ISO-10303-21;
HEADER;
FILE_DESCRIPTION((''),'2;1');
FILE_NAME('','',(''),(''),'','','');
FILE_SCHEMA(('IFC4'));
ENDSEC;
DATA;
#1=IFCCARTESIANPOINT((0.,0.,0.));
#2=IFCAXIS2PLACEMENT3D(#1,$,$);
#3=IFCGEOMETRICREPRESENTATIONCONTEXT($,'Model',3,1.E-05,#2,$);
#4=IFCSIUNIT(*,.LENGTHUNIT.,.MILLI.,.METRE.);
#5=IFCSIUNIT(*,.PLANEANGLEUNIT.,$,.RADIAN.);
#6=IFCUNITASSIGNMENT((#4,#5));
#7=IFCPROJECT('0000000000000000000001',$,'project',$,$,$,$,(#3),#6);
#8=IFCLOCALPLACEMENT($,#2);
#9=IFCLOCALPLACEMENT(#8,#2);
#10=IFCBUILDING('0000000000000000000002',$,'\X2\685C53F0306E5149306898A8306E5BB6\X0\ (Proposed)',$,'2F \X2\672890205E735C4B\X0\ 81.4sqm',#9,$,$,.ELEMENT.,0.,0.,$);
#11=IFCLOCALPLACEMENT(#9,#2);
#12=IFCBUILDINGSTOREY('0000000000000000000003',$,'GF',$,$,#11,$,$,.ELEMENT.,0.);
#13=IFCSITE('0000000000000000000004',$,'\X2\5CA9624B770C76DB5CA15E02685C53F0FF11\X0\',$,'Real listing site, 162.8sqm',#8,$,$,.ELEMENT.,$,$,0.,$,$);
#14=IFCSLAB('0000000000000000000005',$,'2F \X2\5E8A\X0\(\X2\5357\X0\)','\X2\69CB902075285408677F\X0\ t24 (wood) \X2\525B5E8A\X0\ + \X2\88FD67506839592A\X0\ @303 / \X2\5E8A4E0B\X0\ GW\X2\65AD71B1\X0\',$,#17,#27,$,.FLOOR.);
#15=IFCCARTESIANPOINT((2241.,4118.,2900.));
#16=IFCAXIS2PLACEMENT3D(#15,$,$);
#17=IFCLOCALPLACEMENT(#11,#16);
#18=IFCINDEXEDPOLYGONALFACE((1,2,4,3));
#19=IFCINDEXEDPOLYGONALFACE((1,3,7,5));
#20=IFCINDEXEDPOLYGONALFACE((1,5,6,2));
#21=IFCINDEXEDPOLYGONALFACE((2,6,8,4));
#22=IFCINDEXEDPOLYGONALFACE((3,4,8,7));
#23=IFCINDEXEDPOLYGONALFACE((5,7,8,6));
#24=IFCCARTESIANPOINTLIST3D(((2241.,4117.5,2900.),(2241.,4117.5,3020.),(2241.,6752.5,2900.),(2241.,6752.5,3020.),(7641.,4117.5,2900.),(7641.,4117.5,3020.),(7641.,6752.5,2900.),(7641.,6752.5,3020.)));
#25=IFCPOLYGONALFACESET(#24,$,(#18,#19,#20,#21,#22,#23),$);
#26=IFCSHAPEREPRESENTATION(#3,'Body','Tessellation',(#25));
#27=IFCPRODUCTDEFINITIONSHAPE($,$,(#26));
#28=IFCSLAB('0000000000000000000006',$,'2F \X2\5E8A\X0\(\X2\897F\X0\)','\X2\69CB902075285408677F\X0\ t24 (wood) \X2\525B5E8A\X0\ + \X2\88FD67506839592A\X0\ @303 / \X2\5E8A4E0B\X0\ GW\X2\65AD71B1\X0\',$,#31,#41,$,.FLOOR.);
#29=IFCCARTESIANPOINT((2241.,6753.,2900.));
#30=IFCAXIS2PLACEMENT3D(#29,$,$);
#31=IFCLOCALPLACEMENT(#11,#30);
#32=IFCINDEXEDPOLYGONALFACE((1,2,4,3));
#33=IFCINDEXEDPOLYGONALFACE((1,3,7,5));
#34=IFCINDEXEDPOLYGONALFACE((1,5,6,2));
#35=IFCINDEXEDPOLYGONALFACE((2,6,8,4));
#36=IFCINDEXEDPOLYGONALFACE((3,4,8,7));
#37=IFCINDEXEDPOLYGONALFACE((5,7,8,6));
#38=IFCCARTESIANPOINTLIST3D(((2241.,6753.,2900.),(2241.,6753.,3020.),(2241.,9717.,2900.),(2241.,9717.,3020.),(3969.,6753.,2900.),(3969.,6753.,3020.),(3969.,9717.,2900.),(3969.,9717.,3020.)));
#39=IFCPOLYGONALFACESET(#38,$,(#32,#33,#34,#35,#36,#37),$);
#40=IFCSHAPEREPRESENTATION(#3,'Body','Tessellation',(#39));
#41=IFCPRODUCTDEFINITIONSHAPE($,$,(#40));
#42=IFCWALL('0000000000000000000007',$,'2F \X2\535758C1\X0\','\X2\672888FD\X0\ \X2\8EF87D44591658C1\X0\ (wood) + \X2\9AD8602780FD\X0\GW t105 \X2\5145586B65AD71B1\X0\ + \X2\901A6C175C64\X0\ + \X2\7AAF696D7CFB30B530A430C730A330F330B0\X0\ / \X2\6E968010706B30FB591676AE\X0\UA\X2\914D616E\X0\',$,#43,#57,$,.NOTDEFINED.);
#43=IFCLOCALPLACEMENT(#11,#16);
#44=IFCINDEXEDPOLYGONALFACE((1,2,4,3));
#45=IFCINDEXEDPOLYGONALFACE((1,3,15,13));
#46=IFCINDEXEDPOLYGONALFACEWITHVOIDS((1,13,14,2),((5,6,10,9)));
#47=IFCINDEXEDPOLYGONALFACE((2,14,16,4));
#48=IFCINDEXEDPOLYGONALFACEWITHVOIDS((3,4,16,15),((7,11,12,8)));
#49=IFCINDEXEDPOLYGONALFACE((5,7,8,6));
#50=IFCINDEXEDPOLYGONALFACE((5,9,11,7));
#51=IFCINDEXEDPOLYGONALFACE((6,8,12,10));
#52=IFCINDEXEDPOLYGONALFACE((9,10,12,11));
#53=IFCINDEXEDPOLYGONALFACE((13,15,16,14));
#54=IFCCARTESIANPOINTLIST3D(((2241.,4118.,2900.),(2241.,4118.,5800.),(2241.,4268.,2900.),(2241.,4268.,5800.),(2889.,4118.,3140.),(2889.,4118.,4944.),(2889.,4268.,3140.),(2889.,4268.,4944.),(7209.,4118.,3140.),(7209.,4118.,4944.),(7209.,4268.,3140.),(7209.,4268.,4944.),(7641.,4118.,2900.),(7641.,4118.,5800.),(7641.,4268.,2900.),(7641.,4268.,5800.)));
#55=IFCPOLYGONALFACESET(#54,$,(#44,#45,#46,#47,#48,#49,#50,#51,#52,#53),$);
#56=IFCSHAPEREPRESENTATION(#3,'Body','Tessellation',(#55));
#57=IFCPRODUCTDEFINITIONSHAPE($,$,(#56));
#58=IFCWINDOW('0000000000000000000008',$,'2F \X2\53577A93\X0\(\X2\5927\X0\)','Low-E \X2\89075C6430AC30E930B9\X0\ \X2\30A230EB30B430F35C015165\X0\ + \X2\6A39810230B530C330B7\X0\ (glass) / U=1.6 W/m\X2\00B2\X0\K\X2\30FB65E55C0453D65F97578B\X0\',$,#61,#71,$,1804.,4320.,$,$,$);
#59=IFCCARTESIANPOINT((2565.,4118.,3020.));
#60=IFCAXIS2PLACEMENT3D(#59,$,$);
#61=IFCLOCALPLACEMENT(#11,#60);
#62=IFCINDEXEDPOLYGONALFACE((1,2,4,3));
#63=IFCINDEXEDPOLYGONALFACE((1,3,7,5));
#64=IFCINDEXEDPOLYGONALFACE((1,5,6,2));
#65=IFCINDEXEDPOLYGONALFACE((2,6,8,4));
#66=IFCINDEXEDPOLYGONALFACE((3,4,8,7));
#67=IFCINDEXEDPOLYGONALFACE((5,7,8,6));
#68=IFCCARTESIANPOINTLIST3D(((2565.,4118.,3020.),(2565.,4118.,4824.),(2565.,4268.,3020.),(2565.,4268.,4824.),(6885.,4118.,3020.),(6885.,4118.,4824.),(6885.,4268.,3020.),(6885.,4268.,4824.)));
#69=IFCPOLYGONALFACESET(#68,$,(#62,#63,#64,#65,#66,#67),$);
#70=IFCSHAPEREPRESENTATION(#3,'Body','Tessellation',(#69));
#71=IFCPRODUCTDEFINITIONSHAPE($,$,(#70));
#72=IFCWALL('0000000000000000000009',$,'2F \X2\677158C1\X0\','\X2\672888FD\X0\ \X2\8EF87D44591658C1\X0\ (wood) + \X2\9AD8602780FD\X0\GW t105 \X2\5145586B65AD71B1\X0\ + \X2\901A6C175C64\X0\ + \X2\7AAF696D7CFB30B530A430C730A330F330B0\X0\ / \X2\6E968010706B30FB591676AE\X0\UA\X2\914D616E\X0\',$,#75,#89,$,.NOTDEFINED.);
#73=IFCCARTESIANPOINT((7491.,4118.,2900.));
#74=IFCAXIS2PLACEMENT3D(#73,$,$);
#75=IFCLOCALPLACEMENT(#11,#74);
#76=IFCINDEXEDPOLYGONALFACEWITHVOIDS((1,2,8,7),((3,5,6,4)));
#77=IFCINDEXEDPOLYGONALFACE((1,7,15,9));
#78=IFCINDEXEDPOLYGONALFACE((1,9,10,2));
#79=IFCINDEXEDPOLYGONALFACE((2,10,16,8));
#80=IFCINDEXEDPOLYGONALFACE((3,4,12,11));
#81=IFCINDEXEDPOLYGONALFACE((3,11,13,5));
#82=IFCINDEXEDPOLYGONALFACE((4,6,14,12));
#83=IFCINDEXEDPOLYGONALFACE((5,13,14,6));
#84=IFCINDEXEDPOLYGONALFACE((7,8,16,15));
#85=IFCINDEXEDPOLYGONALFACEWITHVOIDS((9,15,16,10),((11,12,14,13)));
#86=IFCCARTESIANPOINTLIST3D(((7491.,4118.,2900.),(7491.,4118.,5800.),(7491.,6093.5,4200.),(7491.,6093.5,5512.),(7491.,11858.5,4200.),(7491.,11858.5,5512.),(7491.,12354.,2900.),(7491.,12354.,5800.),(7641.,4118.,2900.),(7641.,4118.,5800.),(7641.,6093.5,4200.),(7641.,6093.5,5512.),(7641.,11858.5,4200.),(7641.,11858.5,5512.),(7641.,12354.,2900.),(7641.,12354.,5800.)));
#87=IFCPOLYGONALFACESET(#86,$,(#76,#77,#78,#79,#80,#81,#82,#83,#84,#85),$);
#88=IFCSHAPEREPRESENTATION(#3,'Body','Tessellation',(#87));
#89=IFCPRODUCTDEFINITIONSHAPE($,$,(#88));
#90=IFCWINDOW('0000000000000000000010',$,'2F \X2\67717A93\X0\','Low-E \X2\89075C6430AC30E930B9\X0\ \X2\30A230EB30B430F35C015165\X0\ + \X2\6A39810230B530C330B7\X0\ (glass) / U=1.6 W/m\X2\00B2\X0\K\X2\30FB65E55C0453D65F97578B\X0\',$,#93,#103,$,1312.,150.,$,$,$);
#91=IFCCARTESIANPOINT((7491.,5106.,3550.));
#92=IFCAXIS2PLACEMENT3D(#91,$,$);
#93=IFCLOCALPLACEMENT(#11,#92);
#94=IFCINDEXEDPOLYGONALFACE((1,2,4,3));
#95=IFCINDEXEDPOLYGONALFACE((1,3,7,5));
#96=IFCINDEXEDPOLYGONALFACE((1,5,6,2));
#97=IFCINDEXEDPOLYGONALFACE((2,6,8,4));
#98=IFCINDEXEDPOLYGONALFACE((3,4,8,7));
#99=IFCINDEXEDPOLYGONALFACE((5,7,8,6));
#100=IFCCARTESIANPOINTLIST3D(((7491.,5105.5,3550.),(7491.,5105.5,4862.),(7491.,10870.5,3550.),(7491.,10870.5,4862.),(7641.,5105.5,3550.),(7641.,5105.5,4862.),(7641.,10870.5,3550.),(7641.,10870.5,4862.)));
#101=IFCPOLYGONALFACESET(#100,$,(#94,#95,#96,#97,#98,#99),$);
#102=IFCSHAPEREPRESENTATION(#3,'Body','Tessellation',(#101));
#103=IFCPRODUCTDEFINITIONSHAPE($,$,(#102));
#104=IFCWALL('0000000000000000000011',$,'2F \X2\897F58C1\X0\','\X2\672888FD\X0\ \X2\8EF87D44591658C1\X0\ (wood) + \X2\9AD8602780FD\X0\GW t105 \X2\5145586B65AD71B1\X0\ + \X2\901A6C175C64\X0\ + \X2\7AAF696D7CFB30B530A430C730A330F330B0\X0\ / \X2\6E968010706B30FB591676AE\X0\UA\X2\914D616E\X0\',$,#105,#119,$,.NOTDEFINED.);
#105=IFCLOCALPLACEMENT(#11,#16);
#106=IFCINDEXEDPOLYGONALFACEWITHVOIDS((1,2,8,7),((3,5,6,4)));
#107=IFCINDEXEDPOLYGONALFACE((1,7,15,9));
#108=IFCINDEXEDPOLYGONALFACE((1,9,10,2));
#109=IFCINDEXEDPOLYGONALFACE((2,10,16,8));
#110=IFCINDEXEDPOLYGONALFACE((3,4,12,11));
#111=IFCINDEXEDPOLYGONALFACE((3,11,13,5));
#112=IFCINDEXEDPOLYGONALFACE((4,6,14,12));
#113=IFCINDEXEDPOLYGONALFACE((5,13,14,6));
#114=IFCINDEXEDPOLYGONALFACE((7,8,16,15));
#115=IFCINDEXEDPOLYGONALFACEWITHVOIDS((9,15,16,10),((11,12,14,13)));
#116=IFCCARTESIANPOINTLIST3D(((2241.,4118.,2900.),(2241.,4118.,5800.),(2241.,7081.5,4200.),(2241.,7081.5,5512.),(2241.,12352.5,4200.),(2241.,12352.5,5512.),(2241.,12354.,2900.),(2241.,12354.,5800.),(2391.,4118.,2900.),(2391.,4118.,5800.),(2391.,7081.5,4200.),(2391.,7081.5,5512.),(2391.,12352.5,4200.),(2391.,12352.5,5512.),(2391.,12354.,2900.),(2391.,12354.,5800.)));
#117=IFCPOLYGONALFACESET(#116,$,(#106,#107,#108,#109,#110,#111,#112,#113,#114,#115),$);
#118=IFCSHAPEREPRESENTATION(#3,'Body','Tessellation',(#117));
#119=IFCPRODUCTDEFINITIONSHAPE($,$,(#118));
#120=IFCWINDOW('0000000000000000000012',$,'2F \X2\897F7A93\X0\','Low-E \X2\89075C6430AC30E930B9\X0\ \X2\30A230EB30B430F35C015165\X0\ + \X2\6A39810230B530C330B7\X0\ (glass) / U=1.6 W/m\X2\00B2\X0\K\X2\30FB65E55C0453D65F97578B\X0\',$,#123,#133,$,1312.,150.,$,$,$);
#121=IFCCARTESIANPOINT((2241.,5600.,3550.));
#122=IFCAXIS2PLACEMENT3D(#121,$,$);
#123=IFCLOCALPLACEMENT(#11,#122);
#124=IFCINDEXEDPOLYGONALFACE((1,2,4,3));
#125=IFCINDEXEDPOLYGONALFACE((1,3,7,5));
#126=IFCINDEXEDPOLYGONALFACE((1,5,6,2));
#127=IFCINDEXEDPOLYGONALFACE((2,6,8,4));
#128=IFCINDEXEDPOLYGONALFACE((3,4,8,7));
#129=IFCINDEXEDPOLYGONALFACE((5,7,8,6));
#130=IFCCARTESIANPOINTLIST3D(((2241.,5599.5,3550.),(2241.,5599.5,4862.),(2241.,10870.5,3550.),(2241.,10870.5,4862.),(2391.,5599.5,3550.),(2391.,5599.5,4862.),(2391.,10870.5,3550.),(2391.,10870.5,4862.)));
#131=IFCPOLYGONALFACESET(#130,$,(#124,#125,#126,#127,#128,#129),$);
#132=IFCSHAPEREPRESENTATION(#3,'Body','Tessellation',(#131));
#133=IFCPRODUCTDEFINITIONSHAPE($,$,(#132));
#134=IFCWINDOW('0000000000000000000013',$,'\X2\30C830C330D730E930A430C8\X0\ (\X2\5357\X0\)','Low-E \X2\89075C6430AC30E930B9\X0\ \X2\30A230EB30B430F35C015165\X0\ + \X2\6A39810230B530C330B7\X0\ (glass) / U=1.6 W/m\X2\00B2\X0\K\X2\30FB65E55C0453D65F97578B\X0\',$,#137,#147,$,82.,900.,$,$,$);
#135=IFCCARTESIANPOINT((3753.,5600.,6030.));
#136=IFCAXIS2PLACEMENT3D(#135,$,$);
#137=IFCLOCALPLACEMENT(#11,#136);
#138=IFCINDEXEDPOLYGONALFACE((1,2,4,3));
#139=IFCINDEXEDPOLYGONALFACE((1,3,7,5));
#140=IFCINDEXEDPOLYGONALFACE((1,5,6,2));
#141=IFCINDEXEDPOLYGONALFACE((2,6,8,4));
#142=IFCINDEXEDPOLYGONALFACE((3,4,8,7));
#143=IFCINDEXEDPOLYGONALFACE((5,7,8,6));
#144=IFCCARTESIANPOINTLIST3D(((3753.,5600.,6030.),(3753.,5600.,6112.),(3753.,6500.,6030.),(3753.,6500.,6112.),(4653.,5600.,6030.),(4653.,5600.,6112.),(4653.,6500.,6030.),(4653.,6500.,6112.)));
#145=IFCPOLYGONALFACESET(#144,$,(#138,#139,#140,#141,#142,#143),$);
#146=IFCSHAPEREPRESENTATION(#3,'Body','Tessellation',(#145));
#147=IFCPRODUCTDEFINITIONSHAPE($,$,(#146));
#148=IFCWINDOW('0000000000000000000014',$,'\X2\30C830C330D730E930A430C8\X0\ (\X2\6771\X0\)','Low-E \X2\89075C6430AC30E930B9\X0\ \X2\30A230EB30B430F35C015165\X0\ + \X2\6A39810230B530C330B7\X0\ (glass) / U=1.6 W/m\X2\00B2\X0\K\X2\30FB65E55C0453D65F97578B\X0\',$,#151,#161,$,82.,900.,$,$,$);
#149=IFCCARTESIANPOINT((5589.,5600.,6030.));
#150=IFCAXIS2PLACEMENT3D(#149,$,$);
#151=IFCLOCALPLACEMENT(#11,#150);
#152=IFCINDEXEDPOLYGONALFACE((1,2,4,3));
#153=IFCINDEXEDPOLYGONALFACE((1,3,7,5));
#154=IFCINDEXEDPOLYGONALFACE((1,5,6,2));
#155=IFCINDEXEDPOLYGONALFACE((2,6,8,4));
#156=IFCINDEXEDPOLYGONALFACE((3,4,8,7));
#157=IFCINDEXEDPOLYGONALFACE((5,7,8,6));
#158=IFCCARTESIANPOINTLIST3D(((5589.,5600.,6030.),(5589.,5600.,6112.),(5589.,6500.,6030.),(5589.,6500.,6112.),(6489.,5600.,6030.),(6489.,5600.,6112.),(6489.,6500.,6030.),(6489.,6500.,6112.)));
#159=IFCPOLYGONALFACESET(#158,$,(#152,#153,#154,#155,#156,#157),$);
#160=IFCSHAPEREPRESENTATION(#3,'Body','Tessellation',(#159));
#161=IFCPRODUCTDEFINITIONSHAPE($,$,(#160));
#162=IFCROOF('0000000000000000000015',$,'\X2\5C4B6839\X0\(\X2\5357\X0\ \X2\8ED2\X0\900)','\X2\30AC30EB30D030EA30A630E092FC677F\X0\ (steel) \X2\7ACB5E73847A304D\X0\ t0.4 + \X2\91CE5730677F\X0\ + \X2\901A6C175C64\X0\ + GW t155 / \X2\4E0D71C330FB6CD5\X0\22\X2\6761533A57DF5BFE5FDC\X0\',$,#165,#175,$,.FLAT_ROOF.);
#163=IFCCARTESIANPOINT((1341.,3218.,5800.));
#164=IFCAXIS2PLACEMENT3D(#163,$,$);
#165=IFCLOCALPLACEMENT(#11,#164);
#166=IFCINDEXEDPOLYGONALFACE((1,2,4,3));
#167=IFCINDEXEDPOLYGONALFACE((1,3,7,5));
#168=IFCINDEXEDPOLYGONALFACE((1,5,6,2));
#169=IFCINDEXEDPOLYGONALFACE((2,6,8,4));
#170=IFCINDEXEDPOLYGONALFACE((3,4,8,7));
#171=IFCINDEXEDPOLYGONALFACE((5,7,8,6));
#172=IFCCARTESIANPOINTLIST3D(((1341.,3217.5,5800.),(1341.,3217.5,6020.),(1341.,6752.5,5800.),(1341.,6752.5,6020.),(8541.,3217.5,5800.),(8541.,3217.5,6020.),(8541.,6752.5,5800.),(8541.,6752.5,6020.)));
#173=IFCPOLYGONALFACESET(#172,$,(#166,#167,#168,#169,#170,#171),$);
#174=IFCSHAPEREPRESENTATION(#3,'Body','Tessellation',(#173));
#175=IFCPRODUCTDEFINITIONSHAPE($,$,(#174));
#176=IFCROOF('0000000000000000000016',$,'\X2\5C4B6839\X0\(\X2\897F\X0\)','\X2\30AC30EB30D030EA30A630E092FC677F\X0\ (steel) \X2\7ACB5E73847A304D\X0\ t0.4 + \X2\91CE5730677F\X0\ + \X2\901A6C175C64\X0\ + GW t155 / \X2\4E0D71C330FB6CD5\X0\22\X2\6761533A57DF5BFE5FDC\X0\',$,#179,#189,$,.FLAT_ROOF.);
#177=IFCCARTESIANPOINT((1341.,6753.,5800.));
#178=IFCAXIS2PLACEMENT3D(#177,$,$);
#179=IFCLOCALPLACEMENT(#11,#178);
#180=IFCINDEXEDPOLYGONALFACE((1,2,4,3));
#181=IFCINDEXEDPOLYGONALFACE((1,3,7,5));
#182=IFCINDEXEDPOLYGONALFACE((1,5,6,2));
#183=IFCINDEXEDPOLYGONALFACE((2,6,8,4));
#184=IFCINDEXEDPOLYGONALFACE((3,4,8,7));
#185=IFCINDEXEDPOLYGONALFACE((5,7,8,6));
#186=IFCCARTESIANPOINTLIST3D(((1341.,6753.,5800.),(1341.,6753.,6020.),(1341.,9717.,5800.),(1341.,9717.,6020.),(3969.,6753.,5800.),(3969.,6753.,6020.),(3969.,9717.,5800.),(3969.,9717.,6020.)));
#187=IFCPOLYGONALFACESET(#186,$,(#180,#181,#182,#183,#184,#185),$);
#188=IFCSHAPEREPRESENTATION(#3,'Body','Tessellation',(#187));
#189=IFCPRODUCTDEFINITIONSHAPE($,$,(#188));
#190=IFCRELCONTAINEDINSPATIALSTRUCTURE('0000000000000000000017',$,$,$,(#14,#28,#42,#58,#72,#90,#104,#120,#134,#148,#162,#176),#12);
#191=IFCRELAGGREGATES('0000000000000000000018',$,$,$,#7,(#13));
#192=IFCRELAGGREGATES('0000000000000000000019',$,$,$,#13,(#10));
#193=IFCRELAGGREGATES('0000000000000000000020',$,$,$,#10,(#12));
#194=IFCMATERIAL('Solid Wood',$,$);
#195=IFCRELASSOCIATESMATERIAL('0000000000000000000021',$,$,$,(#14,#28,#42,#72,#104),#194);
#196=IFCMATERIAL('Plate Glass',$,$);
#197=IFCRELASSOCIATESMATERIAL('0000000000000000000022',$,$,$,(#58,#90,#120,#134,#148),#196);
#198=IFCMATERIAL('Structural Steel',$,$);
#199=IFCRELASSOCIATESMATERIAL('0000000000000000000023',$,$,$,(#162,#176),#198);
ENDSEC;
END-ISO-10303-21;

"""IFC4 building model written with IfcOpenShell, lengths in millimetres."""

from ifc_helpers import new_model, si_unit, frame, frame_2d, origin, place, context, project, spatial, rectangle, extrude, material, element, fill, save


model = new_model("IFC4")

# Units and contexts
model_context = context("Model", 3, precision=1e-05, world=origin())
ifc_project = project(units=[si_unit("LENGTHUNIT", "METRE", prefix="MILLI"), si_unit("PLANEANGLEUNIT", "RADIAN")], contexts=[model_context])

# Site, building, storey
site_placement = place(None, origin())
site = spatial("IfcSite", under=ifc_project, at=site_placement, Name="岩手県盛岡市桜台１", ObjectType="Real listing site, 162.8sqm", CompositionType="ELEMENT", RefElevation=0.0)
building_placement = place(site_placement, origin())
building = spatial("IfcBuilding", under=site, at=building_placement, Name="桜台の光と風の家 (Proposed)", ObjectType="2F 木造平屋 81.4sqm", CompositionType="ELEMENT", ElevationOfRefHeight=0.0, ElevationOfTerrain=0.0)
storey_placement = place(building_placement, origin())
storey = spatial("IfcBuildingStorey", under=building, at=storey_placement, Name="GF", CompositionType="ELEMENT", Elevation=0.0)

# Slabs
ifc_material_1 = material(Name="Solid Wood")
slab_1_placement = place(storey_placement, frame((2241.0, 4118.0, 2900.0)))
element("IfcSlab", 1, at=slab_1_placement, inside=storey, material=ifc_material_1, Name="2F 床(南)", Description="構造用合板 t24 (wood) 剛床 + 製材根太 @303 / 床下 GW断熱", PredefinedType="FLOOR", context=model_context, shape_type="SweptSolid", body=[
    extrude(rectangle(XDim=5400.0, YDim=2635.0, at=frame_2d((2700.0, 1317.0))), frame((2241.0, 4118.0, 2900.0)), (0.0, 0.0, 1.0), 120.0),
])
slab_2_placement = place(storey_placement, frame((2241.0, 6753.0, 2900.0)))
element("IfcSlab", 2, at=slab_2_placement, inside=storey, material=ifc_material_1, Name="2F 床(西)", Description="構造用合板 t24 (wood) 剛床 + 製材根太 @303 / 床下 GW断熱", PredefinedType="FLOOR", context=model_context, shape_type="SweptSolid", body=[
    extrude(rectangle(XDim=1728.0, YDim=2964.0, at=frame_2d((864.0, 1482.0))), frame((2241.0, 6753.0, 2900.0)), (0.0, 0.0, 1.0), 120.0),
])

# Walls, openings, windows
wall_1_placement = place(storey_placement, frame((2241.0, 4118.0, 2900.0)))
wall_1 = element("IfcWall", 3, at=wall_1_placement, inside=storey, material=ifc_material_1, Name="2F 南壁", Description="木製 軸組外壁 (wood) + 高性能GW t105 充填断熱 + 通気層 + 窯業系サイディング / 準耐火・外皮UA配慮", PredefinedType="NOTDEFINED", context=model_context, shape_type="SweptSolid", body=[
    extrude(rectangle(XDim=5400.0, YDim=150.0, at=frame_2d((2700.0, 75.0))), frame((2241.0, 4118.0, 2900.0)), (0.0, 0.0, 1.0), 2900.0),
])
opening_1_placement = place(storey_placement, frame((2565.0, 4118.0, 3020.0)))
opening_1 = element("IfcOpeningElement", 4, at=opening_1_placement, cuts=wall_1, PredefinedType="NOTDEFINED", context=model_context, shape_type="SweptSolid", body=[
    extrude(rectangle(XDim=4320.0, YDim=150.0, at=frame_2d((2160.0, 75.0))), frame((2565.0, 4118.0, 3020.0)), (0.0, 0.0, 1.0), 1804.0),
])
ifc_material_2 = material(Name="Plate Glass")
window_1_placement = place(storey_placement, frame((2565.0, 4118.0, 3020.0)))
window_1 = element("IfcWindow", 5, at=window_1_placement, inside=storey, material=ifc_material_2, Name="2F 南窓(大)", Description="Low-E 複層ガラス アルゴン封入 + 樹脂サッシ (glass) / U=1.6 W/m²K・日射取得型", OverallHeight=1804.0, OverallWidth=4320.0, context=model_context, shape_type="SweptSolid", body=[
    extrude(rectangle(XDim=4320.0, YDim=150.0, at=frame_2d((2160.0, 75.0))), frame((2565.0, 4118.0, 3020.0)), (0.0, 0.0, 1.0), 1804.0),
])
fill(opening_1, window_1)
wall_2_placement = place(storey_placement, frame((7491.0, 4118.0, 2900.0)))
wall_2 = element("IfcWall", 6, at=wall_2_placement, inside=storey, material=ifc_material_1, Name="2F 東壁", Description="木製 軸組外壁 (wood) + 高性能GW t105 充填断熱 + 通気層 + 窯業系サイディング / 準耐火・外皮UA配慮", PredefinedType="NOTDEFINED", context=model_context, shape_type="SweptSolid", body=[
    extrude(rectangle(XDim=150.0, YDim=8236.0, at=frame_2d((75.0, 4118.0))), frame((7491.0, 4118.0, 2900.0)), (0.0, 0.0, 1.0), 2900.0),
])
opening_2_placement = place(storey_placement, frame((7491.0, 5106.0, 3550.0)))
opening_2 = element("IfcOpeningElement", 7, at=opening_2_placement, cuts=wall_2, PredefinedType="NOTDEFINED", context=model_context, shape_type="SweptSolid", body=[
    extrude(rectangle(XDim=150.0, YDim=5765.0, at=frame_2d((75.0, 2882.0))), frame((7491.0, 5106.0, 3550.0)), (0.0, 0.0, 1.0), 1312.0),
])
window_2_placement = place(storey_placement, frame((7491.0, 5106.0, 3550.0)))
window_2 = element("IfcWindow", 8, at=window_2_placement, inside=storey, material=ifc_material_2, Name="2F 東窓", Description="Low-E 複層ガラス アルゴン封入 + 樹脂サッシ (glass) / U=1.6 W/m²K・日射取得型", OverallHeight=1312.0, OverallWidth=150.0, context=model_context, shape_type="SweptSolid", body=[
    extrude(rectangle(XDim=150.0, YDim=5765.0, at=frame_2d((75.0, 2882.0))), frame((7491.0, 5106.0, 3550.0)), (0.0, 0.0, 1.0), 1312.0),
])
fill(opening_2, window_2)
wall_3_placement = place(storey_placement, frame((2241.0, 4118.0, 2900.0)))
wall_3 = element("IfcWall", 9, at=wall_3_placement, inside=storey, material=ifc_material_1, Name="2F 西壁", Description="木製 軸組外壁 (wood) + 高性能GW t105 充填断熱 + 通気層 + 窯業系サイディング / 準耐火・外皮UA配慮", PredefinedType="NOTDEFINED", context=model_context, shape_type="SweptSolid", body=[
    extrude(rectangle(XDim=150.0, YDim=8236.0, at=frame_2d((75.0, 4118.0))), frame((2241.0, 4118.0, 2900.0)), (0.0, 0.0, 1.0), 2900.0),
])
opening_3_placement = place(storey_placement, frame((2241.0, 5600.0, 3550.0)))
opening_3 = element("IfcOpeningElement", 10, at=opening_3_placement, cuts=wall_3, PredefinedType="NOTDEFINED", context=model_context, shape_type="SweptSolid", body=[
    extrude(rectangle(XDim=150.0, YDim=5271.0, at=frame_2d((75.0, 2635.0))), frame((2241.0, 5600.0, 3550.0)), (0.0, 0.0, 1.0), 1312.0),
])
window_3_placement = place(storey_placement, frame((2241.0, 5600.0, 3550.0)))
window_3 = element("IfcWindow", 11, at=window_3_placement, inside=storey, material=ifc_material_2, Name="2F 西窓", Description="Low-E 複層ガラス アルゴン封入 + 樹脂サッシ (glass) / U=1.6 W/m²K・日射取得型", OverallHeight=1312.0, OverallWidth=150.0, context=model_context, shape_type="SweptSolid", body=[
    extrude(rectangle(XDim=150.0, YDim=5271.0, at=frame_2d((75.0, 2635.0))), frame((2241.0, 5600.0, 3550.0)), (0.0, 0.0, 1.0), 1312.0),
])
fill(opening_3, window_3)

# Windows
window_4_placement = place(storey_placement, frame((3753.0, 5600.0, 6030.0)))
element("IfcWindow", 12, at=window_4_placement, inside=storey, material=ifc_material_2, Name="トップライト (南)", Description="Low-E 複層ガラス アルゴン封入 + 樹脂サッシ (glass) / U=1.6 W/m²K・日射取得型", OverallHeight=82.0, OverallWidth=900.0, context=model_context, shape_type="SweptSolid", body=[
    extrude(rectangle(XDim=900.0, YDim=900.0, at=frame_2d((450.0, 450.0))), frame((3753.0, 5600.0, 6030.0)), (0.0, 0.0, 1.0), 82.0),
])
window_5_placement = place(storey_placement, frame((5589.0, 5600.0, 6030.0)))
element("IfcWindow", 13, at=window_5_placement, inside=storey, material=ifc_material_2, Name="トップライト (東)", Description="Low-E 複層ガラス アルゴン封入 + 樹脂サッシ (glass) / U=1.6 W/m²K・日射取得型", OverallHeight=82.0, OverallWidth=900.0, context=model_context, shape_type="SweptSolid", body=[
    extrude(rectangle(XDim=900.0, YDim=900.0, at=frame_2d((450.0, 450.0))), frame((5589.0, 5600.0, 6030.0)), (0.0, 0.0, 1.0), 82.0),
])

# Roofs
ifc_material_3 = material(Name="Structural Steel")
roof_1_placement = place(storey_placement, frame((1341.0, 3218.0, 5800.0)))
element("IfcRoof", 14, at=roof_1_placement, inside=storey, material=ifc_material_3, Name="屋根(南 軒900)", Description="ガルバリウム鋼板 (steel) 立平葺き t0.4 + 野地板 + 通気層 + GW t155 / 不燃・法22条区域対応", PredefinedType="FLAT_ROOF", context=model_context, shape_type="SweptSolid", body=[
    extrude(rectangle(XDim=7200.0, YDim=3535.0, at=frame_2d((3600.0, 1767.0))), frame((1341.0, 3218.0, 5800.0)), (0.0, 0.0, 1.0), 220.0),
])
roof_2_placement = place(storey_placement, frame((1341.0, 6753.0, 5800.0)))
element("IfcRoof", 15, at=roof_2_placement, inside=storey, material=ifc_material_3, Name="屋根(西)", Description="ガルバリウム鋼板 (steel) 立平葺き t0.4 + 野地板 + 通気層 + GW t155 / 不燃・法22条区域対応", PredefinedType="FLAT_ROOF", context=model_context, shape_type="SweptSolid", body=[
    extrude(rectangle(XDim=2628.0, YDim=2964.0, at=frame_2d((1314.0, 1482.0))), frame((1341.0, 6753.0, 5800.0)), (0.0, 0.0, 1.0), 220.0),
])

save(model, "model.ifc")
